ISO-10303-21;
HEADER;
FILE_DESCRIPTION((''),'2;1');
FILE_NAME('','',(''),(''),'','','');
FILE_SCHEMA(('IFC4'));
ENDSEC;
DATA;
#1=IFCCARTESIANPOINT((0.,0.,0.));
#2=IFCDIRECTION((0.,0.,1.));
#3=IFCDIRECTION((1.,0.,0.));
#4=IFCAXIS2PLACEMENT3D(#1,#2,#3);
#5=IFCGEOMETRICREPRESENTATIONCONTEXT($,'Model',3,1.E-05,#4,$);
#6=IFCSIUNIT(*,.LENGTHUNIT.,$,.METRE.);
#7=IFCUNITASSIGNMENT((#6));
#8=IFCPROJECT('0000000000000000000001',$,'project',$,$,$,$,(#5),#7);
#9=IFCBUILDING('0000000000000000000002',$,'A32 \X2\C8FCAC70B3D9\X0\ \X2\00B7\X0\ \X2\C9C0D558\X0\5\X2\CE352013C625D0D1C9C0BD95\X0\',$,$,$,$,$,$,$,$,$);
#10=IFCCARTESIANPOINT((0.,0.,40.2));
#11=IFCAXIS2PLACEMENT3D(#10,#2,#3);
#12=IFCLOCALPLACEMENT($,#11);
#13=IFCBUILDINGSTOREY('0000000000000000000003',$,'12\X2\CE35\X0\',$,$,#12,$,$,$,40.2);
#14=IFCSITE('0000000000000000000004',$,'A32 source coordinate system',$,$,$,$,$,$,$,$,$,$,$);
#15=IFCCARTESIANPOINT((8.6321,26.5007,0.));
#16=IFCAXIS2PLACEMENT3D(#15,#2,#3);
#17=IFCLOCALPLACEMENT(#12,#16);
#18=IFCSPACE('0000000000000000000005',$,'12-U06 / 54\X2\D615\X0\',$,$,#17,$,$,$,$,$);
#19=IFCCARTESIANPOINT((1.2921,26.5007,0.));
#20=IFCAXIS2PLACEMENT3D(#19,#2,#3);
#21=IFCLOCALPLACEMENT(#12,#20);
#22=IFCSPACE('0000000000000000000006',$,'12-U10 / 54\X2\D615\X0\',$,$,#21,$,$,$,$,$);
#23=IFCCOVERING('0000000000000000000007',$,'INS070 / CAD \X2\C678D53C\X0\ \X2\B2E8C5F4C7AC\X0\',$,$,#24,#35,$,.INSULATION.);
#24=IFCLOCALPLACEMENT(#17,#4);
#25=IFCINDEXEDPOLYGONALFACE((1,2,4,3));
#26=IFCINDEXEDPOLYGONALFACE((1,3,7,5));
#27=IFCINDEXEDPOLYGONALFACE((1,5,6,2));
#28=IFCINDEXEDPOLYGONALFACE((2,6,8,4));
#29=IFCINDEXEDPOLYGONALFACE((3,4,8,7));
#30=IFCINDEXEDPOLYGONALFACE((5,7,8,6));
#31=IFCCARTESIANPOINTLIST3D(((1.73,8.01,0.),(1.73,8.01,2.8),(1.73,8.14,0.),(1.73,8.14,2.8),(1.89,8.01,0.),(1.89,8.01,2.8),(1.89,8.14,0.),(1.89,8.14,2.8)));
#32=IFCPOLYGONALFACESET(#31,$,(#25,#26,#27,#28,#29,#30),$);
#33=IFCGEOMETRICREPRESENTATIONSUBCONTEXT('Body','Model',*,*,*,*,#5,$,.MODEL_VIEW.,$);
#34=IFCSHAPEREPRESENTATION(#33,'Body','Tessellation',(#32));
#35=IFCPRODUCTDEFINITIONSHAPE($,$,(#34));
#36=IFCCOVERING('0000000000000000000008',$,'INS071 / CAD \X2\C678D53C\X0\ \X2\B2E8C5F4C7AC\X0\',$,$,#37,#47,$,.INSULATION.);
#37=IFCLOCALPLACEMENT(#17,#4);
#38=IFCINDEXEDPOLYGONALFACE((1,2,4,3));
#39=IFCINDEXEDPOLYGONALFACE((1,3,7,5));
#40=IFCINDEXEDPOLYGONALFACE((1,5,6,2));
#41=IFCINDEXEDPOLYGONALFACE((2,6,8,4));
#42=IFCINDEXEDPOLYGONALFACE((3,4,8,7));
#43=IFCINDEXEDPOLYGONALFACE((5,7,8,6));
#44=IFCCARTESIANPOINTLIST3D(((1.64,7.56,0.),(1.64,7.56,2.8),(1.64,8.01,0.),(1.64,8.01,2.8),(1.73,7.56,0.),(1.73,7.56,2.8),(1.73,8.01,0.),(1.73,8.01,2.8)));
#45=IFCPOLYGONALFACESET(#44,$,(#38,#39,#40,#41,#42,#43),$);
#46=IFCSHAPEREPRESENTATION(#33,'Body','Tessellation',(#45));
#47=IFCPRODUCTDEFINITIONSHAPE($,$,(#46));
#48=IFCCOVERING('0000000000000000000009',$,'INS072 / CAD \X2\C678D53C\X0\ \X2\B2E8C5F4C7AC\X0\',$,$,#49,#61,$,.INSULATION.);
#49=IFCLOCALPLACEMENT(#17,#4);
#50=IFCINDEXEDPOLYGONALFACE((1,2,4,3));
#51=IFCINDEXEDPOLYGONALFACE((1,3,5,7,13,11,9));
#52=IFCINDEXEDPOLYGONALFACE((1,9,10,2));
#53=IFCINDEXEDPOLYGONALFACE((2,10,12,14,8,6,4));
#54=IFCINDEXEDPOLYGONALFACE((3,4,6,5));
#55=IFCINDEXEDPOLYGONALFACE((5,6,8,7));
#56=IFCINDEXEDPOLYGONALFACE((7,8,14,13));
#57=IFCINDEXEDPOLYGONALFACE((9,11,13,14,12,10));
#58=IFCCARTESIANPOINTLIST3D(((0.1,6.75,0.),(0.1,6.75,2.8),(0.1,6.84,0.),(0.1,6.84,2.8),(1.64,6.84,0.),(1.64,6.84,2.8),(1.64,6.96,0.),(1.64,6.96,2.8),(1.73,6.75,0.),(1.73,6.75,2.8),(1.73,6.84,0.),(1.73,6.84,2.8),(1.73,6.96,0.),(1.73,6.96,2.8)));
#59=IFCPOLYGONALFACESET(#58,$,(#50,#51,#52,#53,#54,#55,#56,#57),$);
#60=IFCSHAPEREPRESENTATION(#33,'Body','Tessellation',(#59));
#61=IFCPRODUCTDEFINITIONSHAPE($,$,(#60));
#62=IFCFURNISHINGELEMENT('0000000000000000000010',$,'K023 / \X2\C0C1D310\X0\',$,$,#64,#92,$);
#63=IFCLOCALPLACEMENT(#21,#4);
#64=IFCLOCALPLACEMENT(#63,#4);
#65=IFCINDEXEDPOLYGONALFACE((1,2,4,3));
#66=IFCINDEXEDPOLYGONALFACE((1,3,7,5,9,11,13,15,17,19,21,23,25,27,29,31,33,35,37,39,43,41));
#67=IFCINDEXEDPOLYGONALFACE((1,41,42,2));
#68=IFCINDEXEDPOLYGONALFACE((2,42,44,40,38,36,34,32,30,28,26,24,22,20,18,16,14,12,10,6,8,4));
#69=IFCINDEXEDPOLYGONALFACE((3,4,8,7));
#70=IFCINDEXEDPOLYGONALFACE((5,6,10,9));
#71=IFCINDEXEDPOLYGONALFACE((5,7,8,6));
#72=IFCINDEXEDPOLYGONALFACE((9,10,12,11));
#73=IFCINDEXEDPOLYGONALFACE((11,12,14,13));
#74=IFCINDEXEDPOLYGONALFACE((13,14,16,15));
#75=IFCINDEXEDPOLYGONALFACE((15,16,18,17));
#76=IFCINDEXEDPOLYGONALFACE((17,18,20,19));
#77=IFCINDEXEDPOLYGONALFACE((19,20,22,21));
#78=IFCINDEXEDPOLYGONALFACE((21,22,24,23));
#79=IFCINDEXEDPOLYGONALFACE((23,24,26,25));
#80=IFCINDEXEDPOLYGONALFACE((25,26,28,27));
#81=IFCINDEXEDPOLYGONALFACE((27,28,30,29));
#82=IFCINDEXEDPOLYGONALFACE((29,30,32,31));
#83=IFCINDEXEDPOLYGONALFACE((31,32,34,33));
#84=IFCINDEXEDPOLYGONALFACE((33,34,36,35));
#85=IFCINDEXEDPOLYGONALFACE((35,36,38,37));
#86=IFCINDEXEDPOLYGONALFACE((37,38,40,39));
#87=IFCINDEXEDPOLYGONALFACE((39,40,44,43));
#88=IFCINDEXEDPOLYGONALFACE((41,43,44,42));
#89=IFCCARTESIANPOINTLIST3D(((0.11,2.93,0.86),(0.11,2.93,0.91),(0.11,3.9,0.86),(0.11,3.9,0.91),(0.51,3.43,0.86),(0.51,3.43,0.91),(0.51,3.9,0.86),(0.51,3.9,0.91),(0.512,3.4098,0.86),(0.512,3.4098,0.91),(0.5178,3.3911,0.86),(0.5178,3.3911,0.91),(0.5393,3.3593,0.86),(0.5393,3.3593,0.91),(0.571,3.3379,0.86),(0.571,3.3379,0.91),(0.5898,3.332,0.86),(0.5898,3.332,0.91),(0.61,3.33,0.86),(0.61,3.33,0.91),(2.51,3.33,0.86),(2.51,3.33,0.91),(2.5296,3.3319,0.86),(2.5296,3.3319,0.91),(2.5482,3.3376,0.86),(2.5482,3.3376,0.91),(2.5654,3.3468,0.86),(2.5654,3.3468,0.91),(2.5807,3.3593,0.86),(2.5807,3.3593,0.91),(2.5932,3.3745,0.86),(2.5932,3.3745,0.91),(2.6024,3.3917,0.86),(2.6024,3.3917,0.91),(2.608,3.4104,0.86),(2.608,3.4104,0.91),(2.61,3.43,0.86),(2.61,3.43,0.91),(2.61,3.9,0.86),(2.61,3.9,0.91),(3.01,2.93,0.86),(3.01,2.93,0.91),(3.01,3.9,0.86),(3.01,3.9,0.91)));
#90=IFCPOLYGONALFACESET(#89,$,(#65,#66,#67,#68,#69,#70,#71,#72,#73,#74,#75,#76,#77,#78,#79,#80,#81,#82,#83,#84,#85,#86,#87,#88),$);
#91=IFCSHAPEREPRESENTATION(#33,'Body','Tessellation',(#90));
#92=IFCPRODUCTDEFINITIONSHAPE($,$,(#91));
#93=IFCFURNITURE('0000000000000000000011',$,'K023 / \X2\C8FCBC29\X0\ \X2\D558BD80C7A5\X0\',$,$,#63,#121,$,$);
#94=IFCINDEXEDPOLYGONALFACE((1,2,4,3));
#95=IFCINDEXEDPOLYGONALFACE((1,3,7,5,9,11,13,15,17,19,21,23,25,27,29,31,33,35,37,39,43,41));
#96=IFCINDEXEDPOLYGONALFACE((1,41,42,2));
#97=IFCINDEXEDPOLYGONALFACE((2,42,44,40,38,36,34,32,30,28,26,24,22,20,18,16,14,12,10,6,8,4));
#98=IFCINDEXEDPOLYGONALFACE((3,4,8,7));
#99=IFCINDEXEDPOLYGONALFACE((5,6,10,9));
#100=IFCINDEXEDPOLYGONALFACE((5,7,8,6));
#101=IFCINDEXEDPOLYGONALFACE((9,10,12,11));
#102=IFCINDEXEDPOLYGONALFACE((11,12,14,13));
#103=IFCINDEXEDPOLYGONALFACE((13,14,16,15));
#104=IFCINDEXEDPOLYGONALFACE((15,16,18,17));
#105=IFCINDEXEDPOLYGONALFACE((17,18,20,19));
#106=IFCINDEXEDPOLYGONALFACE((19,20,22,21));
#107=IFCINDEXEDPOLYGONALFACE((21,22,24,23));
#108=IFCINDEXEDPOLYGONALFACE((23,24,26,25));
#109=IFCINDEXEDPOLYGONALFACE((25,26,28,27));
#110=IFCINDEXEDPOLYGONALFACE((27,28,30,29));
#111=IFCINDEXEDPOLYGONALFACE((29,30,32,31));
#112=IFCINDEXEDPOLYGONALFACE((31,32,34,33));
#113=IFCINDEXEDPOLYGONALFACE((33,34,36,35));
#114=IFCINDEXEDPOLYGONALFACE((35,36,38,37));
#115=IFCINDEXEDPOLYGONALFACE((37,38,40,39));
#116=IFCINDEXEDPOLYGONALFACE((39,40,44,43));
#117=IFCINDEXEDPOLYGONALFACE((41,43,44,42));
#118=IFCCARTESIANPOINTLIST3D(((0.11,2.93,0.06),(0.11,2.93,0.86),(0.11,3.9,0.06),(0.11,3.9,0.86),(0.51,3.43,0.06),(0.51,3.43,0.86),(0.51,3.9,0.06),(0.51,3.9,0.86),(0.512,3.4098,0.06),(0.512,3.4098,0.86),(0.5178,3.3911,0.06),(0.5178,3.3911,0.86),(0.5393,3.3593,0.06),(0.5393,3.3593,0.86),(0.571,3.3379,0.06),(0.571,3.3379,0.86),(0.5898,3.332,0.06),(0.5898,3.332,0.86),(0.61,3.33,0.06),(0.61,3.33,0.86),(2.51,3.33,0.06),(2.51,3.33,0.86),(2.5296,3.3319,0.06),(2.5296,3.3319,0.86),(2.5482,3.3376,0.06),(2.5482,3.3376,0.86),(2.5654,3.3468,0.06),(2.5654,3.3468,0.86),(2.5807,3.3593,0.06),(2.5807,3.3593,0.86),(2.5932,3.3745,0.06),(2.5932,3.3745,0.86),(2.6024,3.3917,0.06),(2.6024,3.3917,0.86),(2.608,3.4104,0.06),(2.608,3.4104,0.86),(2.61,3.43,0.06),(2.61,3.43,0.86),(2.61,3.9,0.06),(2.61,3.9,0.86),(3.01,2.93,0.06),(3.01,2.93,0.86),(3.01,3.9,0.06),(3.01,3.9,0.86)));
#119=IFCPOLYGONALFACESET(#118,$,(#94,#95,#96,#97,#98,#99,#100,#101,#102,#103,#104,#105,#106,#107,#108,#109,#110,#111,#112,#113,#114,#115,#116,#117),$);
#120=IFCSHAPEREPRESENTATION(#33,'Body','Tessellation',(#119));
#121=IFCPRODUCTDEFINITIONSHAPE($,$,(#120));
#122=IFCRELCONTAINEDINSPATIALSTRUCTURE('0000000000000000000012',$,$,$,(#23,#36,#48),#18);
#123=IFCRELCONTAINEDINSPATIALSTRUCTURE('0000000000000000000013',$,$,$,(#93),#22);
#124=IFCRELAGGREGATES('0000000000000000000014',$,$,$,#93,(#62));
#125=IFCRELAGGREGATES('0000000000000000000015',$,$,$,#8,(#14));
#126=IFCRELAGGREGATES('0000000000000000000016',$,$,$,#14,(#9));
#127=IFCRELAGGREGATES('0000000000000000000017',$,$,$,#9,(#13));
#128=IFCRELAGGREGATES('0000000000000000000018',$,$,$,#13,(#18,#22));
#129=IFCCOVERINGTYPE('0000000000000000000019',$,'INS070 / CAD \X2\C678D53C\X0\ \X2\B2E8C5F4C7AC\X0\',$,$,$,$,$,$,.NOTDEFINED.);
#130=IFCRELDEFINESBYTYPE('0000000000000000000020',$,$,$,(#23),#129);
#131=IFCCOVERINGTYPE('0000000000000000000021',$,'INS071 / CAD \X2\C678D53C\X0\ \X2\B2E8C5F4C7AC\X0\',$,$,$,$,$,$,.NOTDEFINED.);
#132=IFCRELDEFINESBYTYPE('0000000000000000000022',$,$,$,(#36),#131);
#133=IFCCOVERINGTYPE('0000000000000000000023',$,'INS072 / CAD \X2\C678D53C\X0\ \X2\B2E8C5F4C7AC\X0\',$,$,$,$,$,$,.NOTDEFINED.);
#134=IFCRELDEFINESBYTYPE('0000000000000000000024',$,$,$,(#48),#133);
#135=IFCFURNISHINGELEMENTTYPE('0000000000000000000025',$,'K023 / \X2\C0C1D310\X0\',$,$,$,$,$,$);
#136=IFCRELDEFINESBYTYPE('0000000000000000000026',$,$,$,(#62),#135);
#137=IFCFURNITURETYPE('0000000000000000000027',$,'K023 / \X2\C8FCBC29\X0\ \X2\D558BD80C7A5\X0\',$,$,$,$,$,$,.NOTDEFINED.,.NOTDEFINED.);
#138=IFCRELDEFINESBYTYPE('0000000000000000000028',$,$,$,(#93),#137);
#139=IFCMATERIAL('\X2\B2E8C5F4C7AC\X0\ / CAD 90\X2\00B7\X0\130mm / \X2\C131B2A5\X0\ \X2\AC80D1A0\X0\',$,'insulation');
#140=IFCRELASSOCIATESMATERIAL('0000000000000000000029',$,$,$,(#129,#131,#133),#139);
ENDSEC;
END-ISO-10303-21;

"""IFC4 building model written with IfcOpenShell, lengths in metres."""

from ifc_helpers import new_model, si_unit, frame, origin, origin_with_axes, place, context, subcontext, project, spatial, polyline, outline, extrude, source, transform, mapped, material, type_object, type_shapes, element, aggregate, save


model = new_model("IFC4")

# Units and contexts
model_context = context("Model", 3, precision=1e-05, world=origin_with_axes())
body_context = subcontext(model_context, "Body", "Model", "MODEL_VIEW")
ifc_project = project(units=[si_unit("LENGTHUNIT", "METRE")], contexts=[model_context])

# Site, building, storey, space
storey_placement = place(None, frame((0.0, 0.0, 40.2), z_axis=(0.0, 0.0, 1.0), x_axis=(1.0, 0.0, 0.0)))
space_1_placement = place(storey_placement, frame((8.6321, 26.5007, 0.0), z_axis=(0.0, 0.0, 1.0), x_axis=(1.0, 0.0, 0.0)))
site = spatial("IfcSite", under=ifc_project, Name="A32 source coordinate system")
building = spatial("IfcBuilding", under=site, Name="A32 주거동 · 지하5층–옥탑지붕")
storey = spatial("IfcBuildingStorey", under=building, at=storey_placement, Name="12층", Elevation=40.2)
space_1 = spatial("IfcSpace", under=storey, at=space_1_placement, Name="12-U06 / 54형")

# Coverings
ifc_material = material(Name="단열재 / CAD 90·130mm / 성능 검토", Category="insulation")
covering_type_1 = type_object("IfcCoveringType", Name="INS070 / CAD 외피 단열재", PredefinedType="NOTDEFINED", material=ifc_material)
shared_shape_1 = source(origin(), body_context, "Body", "SweptSolid", [
    extrude(outline(polyline([(1.73, 8.14), (1.89, 8.14), (1.89, 8.01), (1.73, 8.01), (1.73, 8.14)])), origin(), (0.0, 0.0, 1.0), 2.8),
])
type_shapes(covering_type_1, [shared_shape_1])
covering_1_placement = place(space_1_placement, origin_with_axes())
element("IfcCovering", 1, at=covering_1_placement, inside=space_1, type_object=covering_type_1, Name="INS070 / CAD 외피 단열재", PredefinedType="INSULATION", context=body_context, shape_type="MappedRepresentation", body=[
    mapped(shared_shape_1, transform((0.0, 0.0, 0.0), scale=1.0)),
])
covering_type_2 = type_object("IfcCoveringType", Name="INS071 / CAD 외피 단열재", PredefinedType="NOTDEFINED", material=ifc_material)
shared_shape_2 = source(origin(), body_context, "Body", "SweptSolid", [
    extrude(outline(polyline([(1.73, 7.56), (1.64, 7.56), (1.64, 8.01), (1.73, 8.01), (1.73, 7.56)])), origin(), (0.0, 0.0, 1.0), 2.8),
])
type_shapes(covering_type_2, [shared_shape_2])
covering_2_placement = place(space_1_placement, origin_with_axes())
element("IfcCovering", 2, at=covering_2_placement, inside=space_1, type_object=covering_type_2, Name="INS071 / CAD 외피 단열재", PredefinedType="INSULATION", context=body_context, shape_type="MappedRepresentation", body=[
    mapped(shared_shape_2, transform((0.0, 0.0, 0.0), scale=1.0)),
])
covering_type_3 = type_object("IfcCoveringType", Name="INS072 / CAD 외피 단열재", PredefinedType="NOTDEFINED", material=ifc_material)
shared_shape_3 = source(origin(), body_context, "Body", "SweptSolid", [
    extrude(outline(polyline([(1.64, 6.84), (1.64, 6.96), (1.73, 6.96), (1.73, 6.84), (1.73, 6.75), (0.1, 6.75), (0.1, 6.84), (1.64, 6.84)])), origin(), (0.0, 0.0, 1.0), 2.8),
])
type_shapes(covering_type_3, [shared_shape_3])
covering_3_placement = place(space_1_placement, origin_with_axes())
element("IfcCovering", 3, at=covering_3_placement, inside=space_1, type_object=covering_type_3, Name="INS072 / CAD 외피 단열재", PredefinedType="INSULATION", context=body_context, shape_type="MappedRepresentation", body=[
    mapped(shared_shape_3, transform((0.0, 0.0, 0.0), scale=1.0)),
])

# Shared definitions
space_2_placement = place(storey_placement, frame((1.2921, 26.5007, 0.0), z_axis=(0.0, 0.0, 1.0), x_axis=(1.0, 0.0, 0.0)))

# Furnishing element
furnishing_element_type_1 = type_object("IfcFurnishingElementType", Name="K023 / 상판")
shared_shape_4 = source(origin(), body_context, "Body", "SweptSolid", [
    extrude(outline(polyline([(0.51, 3.43), (0.512, 3.4098), (0.5178, 3.3911), (0.5393, 3.3593), (0.571, 3.3379), (0.5898, 3.332), (0.61, 3.33), (2.51, 3.33), (2.5296, 3.3319), (2.5482, 3.3376), (2.5654, 3.3468), (2.5807, 3.3593), (2.5932, 3.3745), (2.6024, 3.3917), (2.608, 3.4104), (2.61, 3.43), (2.61, 3.9), (3.01, 3.9), (3.01, 2.93), (0.11, 2.93), (0.11, 3.9), (0.51, 3.9), (0.51, 3.43)])), frame((0.0, 0.0, 0.86)), (0.0, 0.0, 1.0), 0.05),
])
type_shapes(furnishing_element_type_1, [shared_shape_4])
furniture_1_placement = place(space_2_placement, origin_with_axes())
furnishing_1_placement = place(furniture_1_placement, origin_with_axes())
furnishing_1 = element("IfcFurnishingElement", 4, at=furnishing_1_placement, type_object=furnishing_element_type_1, Name="K023 / 상판", context=body_context, shape_type="MappedRepresentation", body=[
    mapped(shared_shape_4, transform((0.0, 0.0, 0.0), scale=1.0)),
])

# Shared definitions
space_2 = spatial("IfcSpace", under=storey, at=space_2_placement, Name="12-U10 / 54형")

# Furniture
furniture_type_1 = type_object("IfcFurnitureType", Name="K023 / 주방 하부장", AssemblyPlace="NOTDEFINED", PredefinedType="NOTDEFINED")
shared_shape_5 = source(origin(), body_context, "Body", "SweptSolid", [
    extrude(outline(polyline([(0.51, 3.9), (0.51, 3.43), (0.512, 3.4098), (0.5178, 3.3911), (0.5393, 3.3593), (0.571, 3.3379), (0.5898, 3.332), (0.61, 3.33), (2.51, 3.33), (2.5296, 3.3319), (2.5482, 3.3376), (2.5654, 3.3468), (2.5807, 3.3593), (2.5932, 3.3745), (2.6024, 3.3917), (2.608, 3.4104), (2.61, 3.43), (2.61, 3.9), (3.01, 3.9), (3.01, 2.93), (0.11, 2.93), (0.11, 3.9), (0.51, 3.9)])), frame((0.0, 0.0, 0.06)), (0.0, 0.0, 1.0), 0.8),
])
type_shapes(furniture_type_1, [shared_shape_5])
furniture_1 = element("IfcFurniture", 5, at=furniture_1_placement, inside=space_2, type_object=furniture_type_1, Name="K023 / 주방 하부장", context=body_context, shape_type="MappedRepresentation", body=[
    mapped(shared_shape_5, transform((0.0, 0.0, 0.0), scale=1.0)),
])
aggregate(furniture_1, [furnishing_1])

save(model, "model.ifc")
